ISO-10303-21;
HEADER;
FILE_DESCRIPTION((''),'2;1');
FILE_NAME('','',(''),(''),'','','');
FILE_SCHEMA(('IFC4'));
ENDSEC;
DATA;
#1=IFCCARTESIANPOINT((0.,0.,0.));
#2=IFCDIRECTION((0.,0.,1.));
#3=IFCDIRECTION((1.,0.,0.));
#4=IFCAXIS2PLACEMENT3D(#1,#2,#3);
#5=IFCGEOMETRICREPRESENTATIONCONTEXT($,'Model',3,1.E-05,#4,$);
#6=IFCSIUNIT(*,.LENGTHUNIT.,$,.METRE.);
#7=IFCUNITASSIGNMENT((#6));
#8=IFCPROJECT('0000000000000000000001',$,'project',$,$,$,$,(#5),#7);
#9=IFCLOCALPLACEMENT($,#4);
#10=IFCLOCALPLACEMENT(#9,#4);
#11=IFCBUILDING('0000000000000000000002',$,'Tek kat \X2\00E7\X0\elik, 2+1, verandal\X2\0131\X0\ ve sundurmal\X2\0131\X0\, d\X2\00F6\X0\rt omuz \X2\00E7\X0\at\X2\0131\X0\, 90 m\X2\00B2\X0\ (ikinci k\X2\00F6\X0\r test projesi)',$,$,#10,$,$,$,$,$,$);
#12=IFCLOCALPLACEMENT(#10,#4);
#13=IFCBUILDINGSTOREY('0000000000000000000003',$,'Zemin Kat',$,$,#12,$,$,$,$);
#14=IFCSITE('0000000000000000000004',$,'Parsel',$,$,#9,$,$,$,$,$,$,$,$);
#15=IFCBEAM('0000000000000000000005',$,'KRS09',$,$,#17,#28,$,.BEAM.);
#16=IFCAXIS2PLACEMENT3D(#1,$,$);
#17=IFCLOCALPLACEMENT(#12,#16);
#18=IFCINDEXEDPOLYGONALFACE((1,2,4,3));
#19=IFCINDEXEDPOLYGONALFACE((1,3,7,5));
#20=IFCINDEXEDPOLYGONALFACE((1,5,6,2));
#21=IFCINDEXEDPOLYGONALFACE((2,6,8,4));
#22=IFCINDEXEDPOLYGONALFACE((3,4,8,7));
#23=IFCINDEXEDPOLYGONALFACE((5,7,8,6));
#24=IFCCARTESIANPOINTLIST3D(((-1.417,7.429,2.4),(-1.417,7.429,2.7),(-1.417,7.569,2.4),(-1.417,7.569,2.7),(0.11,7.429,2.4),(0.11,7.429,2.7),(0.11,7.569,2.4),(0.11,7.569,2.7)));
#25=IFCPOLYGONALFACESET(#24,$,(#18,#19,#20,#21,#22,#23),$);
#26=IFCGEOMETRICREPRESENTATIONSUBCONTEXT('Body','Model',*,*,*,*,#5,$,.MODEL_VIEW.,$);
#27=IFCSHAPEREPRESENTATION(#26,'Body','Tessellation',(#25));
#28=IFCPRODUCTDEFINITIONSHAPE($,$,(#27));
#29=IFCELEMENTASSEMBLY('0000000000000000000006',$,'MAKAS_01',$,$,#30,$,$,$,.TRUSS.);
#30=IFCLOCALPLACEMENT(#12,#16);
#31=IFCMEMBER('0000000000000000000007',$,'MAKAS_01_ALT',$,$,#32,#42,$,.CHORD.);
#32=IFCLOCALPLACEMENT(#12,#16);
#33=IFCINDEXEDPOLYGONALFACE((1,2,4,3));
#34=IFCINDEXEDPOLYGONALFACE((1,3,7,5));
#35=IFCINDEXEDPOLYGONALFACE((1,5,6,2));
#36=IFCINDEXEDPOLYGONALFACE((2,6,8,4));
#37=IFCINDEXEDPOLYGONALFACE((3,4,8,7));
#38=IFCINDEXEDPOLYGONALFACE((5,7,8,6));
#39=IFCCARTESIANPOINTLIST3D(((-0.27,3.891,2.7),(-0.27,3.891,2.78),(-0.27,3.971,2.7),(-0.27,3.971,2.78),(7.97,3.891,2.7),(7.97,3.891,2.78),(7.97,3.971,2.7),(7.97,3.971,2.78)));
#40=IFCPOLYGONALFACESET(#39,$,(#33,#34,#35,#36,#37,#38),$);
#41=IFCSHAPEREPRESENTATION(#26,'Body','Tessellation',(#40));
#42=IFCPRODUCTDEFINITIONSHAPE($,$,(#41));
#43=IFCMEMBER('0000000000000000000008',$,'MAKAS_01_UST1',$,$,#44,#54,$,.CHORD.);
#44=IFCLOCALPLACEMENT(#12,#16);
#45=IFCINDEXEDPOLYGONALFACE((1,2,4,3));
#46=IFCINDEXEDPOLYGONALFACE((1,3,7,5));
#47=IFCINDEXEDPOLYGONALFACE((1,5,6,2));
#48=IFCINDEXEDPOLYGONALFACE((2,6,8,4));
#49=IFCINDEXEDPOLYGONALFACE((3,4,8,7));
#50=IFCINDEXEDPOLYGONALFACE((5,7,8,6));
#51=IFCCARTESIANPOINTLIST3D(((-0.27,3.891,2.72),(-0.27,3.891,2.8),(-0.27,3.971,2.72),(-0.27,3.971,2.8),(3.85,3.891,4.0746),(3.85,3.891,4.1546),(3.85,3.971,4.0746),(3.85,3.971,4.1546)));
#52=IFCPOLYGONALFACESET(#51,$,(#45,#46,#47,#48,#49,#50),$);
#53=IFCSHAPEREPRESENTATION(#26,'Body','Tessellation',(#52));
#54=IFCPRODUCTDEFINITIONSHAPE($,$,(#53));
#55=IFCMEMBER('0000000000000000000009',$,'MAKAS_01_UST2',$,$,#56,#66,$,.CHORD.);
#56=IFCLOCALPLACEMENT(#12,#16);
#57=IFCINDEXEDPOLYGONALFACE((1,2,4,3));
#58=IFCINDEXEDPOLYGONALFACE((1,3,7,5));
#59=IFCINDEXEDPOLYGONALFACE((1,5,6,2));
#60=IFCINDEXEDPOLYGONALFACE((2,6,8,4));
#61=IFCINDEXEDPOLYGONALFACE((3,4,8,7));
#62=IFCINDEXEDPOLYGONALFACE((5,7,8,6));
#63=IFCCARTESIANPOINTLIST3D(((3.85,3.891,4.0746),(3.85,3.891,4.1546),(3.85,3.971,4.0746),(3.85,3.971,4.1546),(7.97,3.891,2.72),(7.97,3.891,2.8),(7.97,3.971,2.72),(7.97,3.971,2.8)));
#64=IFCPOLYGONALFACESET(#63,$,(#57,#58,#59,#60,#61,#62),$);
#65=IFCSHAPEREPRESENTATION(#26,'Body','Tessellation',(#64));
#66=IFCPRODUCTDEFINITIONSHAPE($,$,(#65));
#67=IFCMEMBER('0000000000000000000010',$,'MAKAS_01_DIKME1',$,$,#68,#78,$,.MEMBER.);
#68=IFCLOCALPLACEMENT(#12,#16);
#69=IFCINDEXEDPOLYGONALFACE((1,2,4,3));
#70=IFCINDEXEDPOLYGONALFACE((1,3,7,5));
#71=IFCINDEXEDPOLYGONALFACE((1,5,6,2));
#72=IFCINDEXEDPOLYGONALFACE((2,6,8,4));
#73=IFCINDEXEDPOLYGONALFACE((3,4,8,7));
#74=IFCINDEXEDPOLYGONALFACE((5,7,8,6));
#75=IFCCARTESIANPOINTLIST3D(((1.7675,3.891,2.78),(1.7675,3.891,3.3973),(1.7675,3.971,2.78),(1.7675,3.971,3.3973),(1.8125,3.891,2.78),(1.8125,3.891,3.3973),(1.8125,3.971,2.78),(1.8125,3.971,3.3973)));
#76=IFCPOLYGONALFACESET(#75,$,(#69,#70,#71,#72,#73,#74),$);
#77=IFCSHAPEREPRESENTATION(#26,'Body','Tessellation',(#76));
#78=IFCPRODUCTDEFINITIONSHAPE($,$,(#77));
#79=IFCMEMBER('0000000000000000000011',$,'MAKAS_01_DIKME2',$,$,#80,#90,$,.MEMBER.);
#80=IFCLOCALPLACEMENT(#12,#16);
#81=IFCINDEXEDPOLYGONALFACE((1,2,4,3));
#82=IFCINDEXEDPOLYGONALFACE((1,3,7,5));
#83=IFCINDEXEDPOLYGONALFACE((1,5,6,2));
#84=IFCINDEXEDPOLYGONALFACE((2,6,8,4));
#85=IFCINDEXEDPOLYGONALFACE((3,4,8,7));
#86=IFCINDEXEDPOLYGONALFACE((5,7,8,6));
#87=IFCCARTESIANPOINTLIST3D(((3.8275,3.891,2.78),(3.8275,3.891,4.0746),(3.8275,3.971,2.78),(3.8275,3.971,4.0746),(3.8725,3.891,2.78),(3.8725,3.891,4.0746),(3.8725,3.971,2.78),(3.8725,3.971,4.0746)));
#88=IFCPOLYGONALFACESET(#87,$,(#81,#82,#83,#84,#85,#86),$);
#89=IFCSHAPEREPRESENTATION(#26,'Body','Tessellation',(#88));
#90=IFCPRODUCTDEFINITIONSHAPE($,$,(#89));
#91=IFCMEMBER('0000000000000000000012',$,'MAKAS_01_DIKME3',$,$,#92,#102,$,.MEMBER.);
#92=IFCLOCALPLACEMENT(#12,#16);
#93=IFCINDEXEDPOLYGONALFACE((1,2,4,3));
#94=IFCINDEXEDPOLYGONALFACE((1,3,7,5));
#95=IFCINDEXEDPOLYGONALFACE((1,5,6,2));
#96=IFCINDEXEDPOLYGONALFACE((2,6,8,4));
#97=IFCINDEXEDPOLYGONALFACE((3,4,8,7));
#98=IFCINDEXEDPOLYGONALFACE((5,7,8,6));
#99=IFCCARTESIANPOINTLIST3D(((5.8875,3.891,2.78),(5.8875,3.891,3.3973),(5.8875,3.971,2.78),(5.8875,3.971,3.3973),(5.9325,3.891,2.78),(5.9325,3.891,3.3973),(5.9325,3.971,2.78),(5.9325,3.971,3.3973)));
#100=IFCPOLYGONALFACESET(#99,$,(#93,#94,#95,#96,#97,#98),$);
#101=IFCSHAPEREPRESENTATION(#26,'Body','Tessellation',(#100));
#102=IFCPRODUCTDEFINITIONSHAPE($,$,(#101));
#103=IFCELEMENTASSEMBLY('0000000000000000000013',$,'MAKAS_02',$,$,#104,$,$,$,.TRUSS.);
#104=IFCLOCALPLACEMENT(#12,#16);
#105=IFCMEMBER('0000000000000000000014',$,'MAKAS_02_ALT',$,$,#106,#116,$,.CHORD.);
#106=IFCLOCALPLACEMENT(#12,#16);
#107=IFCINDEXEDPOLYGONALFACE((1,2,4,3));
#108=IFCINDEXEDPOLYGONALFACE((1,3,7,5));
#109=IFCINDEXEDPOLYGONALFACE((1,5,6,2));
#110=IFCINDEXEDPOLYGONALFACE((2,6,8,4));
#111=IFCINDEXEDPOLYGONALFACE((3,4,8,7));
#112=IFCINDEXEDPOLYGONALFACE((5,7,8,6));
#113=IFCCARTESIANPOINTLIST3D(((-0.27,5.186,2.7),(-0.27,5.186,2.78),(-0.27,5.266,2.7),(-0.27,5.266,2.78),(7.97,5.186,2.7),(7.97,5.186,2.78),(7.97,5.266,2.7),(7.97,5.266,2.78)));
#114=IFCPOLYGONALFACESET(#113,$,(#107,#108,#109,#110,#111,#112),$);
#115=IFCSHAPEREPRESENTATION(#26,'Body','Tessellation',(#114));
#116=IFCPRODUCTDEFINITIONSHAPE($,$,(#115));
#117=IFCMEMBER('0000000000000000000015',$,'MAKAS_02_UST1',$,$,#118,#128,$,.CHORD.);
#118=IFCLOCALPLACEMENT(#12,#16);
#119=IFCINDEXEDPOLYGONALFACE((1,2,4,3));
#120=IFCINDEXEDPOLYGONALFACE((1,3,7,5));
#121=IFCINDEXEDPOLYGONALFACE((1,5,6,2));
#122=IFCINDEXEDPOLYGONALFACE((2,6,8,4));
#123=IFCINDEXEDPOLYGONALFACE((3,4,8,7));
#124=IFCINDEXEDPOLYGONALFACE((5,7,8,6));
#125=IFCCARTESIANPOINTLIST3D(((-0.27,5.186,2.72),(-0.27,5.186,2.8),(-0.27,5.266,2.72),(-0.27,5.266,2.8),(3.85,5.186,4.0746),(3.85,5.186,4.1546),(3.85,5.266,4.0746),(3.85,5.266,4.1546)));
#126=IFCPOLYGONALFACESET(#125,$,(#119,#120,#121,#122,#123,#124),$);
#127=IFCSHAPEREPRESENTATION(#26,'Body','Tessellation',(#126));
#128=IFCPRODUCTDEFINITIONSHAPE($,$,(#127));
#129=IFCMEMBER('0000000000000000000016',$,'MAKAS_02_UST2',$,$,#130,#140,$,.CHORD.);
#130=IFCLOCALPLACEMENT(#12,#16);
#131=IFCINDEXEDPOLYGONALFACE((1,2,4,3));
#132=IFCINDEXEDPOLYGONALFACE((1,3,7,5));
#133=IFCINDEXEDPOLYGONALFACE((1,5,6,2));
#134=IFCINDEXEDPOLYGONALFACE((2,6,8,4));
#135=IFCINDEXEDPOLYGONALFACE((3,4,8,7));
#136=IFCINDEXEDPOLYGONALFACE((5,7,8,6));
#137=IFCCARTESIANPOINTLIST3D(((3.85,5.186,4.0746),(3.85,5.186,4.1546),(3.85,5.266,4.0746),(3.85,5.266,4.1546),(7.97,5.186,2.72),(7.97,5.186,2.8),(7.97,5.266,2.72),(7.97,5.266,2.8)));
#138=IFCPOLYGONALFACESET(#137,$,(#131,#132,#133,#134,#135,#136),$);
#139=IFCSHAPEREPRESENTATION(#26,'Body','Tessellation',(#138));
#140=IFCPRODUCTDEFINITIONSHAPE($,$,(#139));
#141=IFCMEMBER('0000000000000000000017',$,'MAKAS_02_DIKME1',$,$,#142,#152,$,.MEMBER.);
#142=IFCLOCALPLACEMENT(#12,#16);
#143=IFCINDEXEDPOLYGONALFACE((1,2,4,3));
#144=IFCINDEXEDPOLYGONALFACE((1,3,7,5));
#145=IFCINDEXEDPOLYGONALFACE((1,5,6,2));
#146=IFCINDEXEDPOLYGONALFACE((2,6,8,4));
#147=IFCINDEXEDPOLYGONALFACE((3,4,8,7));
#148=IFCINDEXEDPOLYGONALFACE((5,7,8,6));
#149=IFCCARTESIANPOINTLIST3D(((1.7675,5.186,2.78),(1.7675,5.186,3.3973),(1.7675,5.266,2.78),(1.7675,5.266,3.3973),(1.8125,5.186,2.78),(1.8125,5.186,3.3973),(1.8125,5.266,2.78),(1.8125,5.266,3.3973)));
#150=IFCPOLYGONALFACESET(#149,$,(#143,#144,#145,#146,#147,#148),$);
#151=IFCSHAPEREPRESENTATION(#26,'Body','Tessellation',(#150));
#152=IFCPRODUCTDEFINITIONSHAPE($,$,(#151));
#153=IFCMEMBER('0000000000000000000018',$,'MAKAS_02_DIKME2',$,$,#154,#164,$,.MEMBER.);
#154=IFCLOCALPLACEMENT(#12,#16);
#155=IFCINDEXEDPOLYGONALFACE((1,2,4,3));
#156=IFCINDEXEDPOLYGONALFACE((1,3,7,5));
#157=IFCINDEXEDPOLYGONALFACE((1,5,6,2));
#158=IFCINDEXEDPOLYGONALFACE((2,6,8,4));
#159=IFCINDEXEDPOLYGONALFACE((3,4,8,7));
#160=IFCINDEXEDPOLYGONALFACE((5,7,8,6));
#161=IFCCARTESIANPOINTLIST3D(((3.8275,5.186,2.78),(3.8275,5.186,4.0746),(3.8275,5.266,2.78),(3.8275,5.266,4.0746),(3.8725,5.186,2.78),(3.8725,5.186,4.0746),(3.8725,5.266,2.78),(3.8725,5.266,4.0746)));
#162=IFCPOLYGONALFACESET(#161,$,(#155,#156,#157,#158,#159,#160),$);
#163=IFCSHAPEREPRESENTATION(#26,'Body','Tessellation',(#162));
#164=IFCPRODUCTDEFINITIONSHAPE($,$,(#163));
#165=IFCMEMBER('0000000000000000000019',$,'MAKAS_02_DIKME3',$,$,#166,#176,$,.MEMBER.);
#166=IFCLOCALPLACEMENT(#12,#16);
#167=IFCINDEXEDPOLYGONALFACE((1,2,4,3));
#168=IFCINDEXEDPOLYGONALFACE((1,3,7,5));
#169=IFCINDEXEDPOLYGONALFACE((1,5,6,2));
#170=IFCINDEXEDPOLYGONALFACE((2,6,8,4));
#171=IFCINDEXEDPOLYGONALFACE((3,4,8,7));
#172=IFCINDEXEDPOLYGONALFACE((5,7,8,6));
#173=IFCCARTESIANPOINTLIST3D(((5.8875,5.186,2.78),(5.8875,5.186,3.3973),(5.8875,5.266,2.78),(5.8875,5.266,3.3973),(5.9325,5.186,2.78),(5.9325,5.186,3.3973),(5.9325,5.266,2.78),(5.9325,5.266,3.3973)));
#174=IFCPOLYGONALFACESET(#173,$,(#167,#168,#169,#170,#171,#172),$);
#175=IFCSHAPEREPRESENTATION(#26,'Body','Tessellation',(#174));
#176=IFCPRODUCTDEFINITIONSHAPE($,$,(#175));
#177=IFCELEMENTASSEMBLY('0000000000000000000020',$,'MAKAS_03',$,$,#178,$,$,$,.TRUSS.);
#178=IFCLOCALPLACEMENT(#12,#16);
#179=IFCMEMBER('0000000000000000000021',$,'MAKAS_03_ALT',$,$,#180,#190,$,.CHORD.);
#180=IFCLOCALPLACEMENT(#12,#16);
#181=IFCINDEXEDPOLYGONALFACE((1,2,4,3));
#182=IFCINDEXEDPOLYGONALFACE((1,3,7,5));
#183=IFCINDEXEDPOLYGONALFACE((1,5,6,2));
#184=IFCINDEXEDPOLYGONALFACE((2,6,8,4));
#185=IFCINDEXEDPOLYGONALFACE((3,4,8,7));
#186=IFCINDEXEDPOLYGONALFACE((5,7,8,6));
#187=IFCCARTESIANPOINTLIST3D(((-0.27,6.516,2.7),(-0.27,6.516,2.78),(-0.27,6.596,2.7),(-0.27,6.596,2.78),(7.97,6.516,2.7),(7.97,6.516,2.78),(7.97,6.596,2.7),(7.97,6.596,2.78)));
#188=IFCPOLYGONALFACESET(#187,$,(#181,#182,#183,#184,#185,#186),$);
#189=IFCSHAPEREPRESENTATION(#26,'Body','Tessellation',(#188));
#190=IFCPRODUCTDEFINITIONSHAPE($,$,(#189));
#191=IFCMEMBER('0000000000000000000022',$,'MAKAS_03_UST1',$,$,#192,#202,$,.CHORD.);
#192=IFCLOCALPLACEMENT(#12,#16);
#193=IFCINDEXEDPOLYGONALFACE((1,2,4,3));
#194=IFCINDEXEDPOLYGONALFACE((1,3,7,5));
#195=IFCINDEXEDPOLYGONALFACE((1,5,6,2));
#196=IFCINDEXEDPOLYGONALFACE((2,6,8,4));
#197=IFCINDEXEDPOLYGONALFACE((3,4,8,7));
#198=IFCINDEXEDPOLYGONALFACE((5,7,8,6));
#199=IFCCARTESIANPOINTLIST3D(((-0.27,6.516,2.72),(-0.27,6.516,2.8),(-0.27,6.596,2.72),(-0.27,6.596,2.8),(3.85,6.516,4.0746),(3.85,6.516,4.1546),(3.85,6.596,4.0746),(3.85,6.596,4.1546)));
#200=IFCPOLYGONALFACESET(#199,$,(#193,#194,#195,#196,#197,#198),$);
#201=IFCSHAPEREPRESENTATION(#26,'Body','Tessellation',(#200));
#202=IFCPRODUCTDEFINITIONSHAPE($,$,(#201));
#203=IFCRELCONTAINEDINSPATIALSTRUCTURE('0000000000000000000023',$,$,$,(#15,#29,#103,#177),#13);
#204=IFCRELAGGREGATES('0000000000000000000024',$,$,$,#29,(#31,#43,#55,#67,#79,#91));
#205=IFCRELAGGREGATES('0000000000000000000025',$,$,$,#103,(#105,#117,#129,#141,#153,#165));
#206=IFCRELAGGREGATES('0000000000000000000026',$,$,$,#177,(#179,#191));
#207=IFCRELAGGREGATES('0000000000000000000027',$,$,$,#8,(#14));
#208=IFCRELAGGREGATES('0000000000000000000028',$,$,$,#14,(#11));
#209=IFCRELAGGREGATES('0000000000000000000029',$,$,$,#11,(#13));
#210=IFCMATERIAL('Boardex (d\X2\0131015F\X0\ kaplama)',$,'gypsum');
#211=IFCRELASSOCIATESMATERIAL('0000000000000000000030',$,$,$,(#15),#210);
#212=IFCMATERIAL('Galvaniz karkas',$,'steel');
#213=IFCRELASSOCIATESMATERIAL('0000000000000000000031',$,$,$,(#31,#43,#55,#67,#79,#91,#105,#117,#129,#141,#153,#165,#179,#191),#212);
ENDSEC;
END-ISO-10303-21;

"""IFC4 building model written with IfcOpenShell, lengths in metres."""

from ifc_helpers import new_model, si_unit, frame, origin_with_axes, place, context, subcontext, project, spatial, line, indexed_curve, outline, extrude, material, element, aggregate, save


model = new_model("IFC4")

# Units and contexts
model_context = context("Model", 3, precision=1e-05, world=origin_with_axes())
body_context = subcontext(model_context, "Body", "Model", "MODEL_VIEW")
ifc_project = project(units=[si_unit("LENGTHUNIT", "METRE")], contexts=[model_context])

# Site, building, storey
site_placement = place(None, origin_with_axes())
site = spatial("IfcSite", under=ifc_project, at=site_placement, Name="Parsel")
building_placement = place(site_placement, origin_with_axes())
building = spatial("IfcBuilding", under=site, at=building_placement, Name="Tek kat çelik, 2+1, verandalı ve sundurmalı, dört omuz çatı, 90 m² (ikinci kör test projesi)")
storey_placement = place(building_placement, origin_with_axes())
storey = spatial("IfcBuildingStorey", under=building, at=storey_placement, Name="Zemin Kat")

# Beam
ifc_material_1 = material(Name="Boardex (dış kaplama)", Category="gypsum")
beam_placement = place(storey_placement, origin_with_axes())
element("IfcBeam", 1, at=beam_placement, inside=storey, material=ifc_material_1, Name="KRS09", PredefinedType="BEAM", context=body_context, shape_type="SweptSolid", body=[
    extrude(outline(indexed_curve([(0.0, 0.0), (1.527, 0.0), (1.527, 0.14), (0.0, 0.14)], segments=[line(1, 2, 3, 4, 1)])), frame((-1.417, 7.429, 2.4), z_axis=(0.0, 0.0, 1.0), x_axis=(1.0, 0.0, 0.0)), (0.0, 0.0, 1.0), 0.3),
])

# Element assemblies, members
assembly_1_placement = place(storey_placement, origin_with_axes())
assembly_1 = element("IfcElementAssembly", 2, at=assembly_1_placement, inside=storey, Name="MAKAS_01", PredefinedType="TRUSS")
ifc_material_2 = material(Name="Galvaniz karkas", Category="steel")
member_1_placement = place(assembly_1_placement, origin_with_axes())
member_1 = element("IfcMember", 3, at=member_1_placement, material=ifc_material_2, Name="MAKAS_01_ALT", PredefinedType="CHORD", context=body_context, shape_type="SweptSolid", body=[
    extrude(outline(indexed_curve([(-0.27, 2.7), (7.97, 2.7), (7.97, 2.78), (-0.27, 2.78)], segments=[line(1, 2, 3, 4, 1)])), frame((0.0, 3.971, 0.0), z_axis=(0.0, -1.0, 0.0), x_axis=(1.0, 0.0, 0.0)), (0.0, 0.0, 1.0), 0.08),
])
member_2_placement = place(assembly_1_placement, origin_with_axes())
member_2 = element("IfcMember", 4, at=member_2_placement, material=ifc_material_2, Name="MAKAS_01_UST1", PredefinedType="CHORD", context=body_context, shape_type="SweptSolid", body=[
    extrude(outline(indexed_curve([(-0.27, 2.72), (3.85, 4.0746), (3.85, 4.1546), (-0.27, 2.8)], segments=[line(1, 2, 3, 4, 1)])), frame((0.0, 3.971, 0.0), z_axis=(0.0, -1.0, 0.0), x_axis=(1.0, 0.0, 0.0)), (0.0, 0.0, 1.0), 0.08),
])
member_3_placement = place(assembly_1_placement, origin_with_axes())
member_3 = element("IfcMember", 5, at=member_3_placement, material=ifc_material_2, Name="MAKAS_01_UST2", PredefinedType="CHORD", context=body_context, shape_type="SweptSolid", body=[
    extrude(outline(indexed_curve([(3.85, 4.0746), (7.97, 2.72), (7.97, 2.8), (3.85, 4.1546)], segments=[line(1, 2, 3, 4, 1)])), frame((0.0, 3.971, 0.0), z_axis=(0.0, -1.0, 0.0), x_axis=(1.0, 0.0, 0.0)), (0.0, 0.0, 1.0), 0.08),
])
member_4_placement = place(assembly_1_placement, origin_with_axes())
member_4 = element("IfcMember", 6, at=member_4_placement, material=ifc_material_2, Name="MAKAS_01_DIKME1", PredefinedType="MEMBER", context=body_context, shape_type="SweptSolid", body=[
    extrude(outline(indexed_curve([(1.7675, 2.78), (1.8125, 2.78), (1.8125, 3.3973), (1.7675, 3.3973)], segments=[line(1, 2, 3, 4, 1)])), frame((0.0, 3.971, 0.0), z_axis=(0.0, -1.0, 0.0), x_axis=(1.0, 0.0, 0.0)), (0.0, 0.0, 1.0), 0.08),
])
member_5_placement = place(assembly_1_placement, origin_with_axes())
member_5 = element("IfcMember", 7, at=member_5_placement, material=ifc_material_2, Name="MAKAS_01_DIKME2", PredefinedType="MEMBER", context=body_context, shape_type="SweptSolid", body=[
    extrude(outline(indexed_curve([(3.8275, 2.78), (3.8725, 2.78), (3.8725, 4.0746), (3.8275, 4.0746)], segments=[line(1, 2, 3, 4, 1)])), frame((0.0, 3.971, 0.0), z_axis=(0.0, -1.0, 0.0), x_axis=(1.0, 0.0, 0.0)), (0.0, 0.0, 1.0), 0.08),
])
member_6_placement = place(assembly_1_placement, origin_with_axes())
member_6 = element("IfcMember", 8, at=member_6_placement, material=ifc_material_2, Name="MAKAS_01_DIKME3", PredefinedType="MEMBER", context=body_context, shape_type="SweptSolid", body=[
    extrude(outline(indexed_curve([(5.8875, 2.78), (5.9325, 2.78), (5.9325, 3.3973), (5.8875, 3.3973)], segments=[line(1, 2, 3, 4, 1)])), frame((0.0, 3.971, 0.0), z_axis=(0.0, -1.0, 0.0), x_axis=(1.0, 0.0, 0.0)), (0.0, 0.0, 1.0), 0.08),
])
aggregate(assembly_1, [member_1, member_2, member_3, member_4, member_5, member_6])
assembly_2_placement = place(storey_placement, origin_with_axes())
assembly_2 = element("IfcElementAssembly", 9, at=assembly_2_placement, inside=storey, Name="MAKAS_02", PredefinedType="TRUSS")
member_7_placement = place(assembly_2_placement, origin_with_axes())
member_7 = element("IfcMember", 10, at=member_7_placement, material=ifc_material_2, Name="MAKAS_02_ALT", PredefinedType="CHORD", context=body_context, shape_type="SweptSolid", body=[
    extrude(outline(indexed_curve([(-0.27, 2.7), (7.97, 2.7), (7.97, 2.78), (-0.27, 2.78)], segments=[line(1, 2, 3, 4, 1)])), frame((0.0, 5.266, 0.0), z_axis=(0.0, -1.0, 0.0), x_axis=(1.0, 0.0, 0.0)), (0.0, 0.0, 1.0), 0.08),
])
member_8_placement = place(assembly_2_placement, origin_with_axes())
member_8 = element("IfcMember", 11, at=member_8_placement, material=ifc_material_2, Name="MAKAS_02_UST1", PredefinedType="CHORD", context=body_context, shape_type="SweptSolid", body=[
    extrude(outline(indexed_curve([(-0.27, 2.72), (3.85, 4.0746), (3.85, 4.1546), (-0.27, 2.8)], segments=[line(1, 2, 3, 4, 1)])), frame((0.0, 5.266, 0.0), z_axis=(0.0, -1.0, 0.0), x_axis=(1.0, 0.0, 0.0)), (0.0, 0.0, 1.0), 0.08),
])
member_9_placement = place(assembly_2_placement, origin_with_axes())
member_9 = element("IfcMember", 12, at=member_9_placement, material=ifc_material_2, Name="MAKAS_02_UST2", PredefinedType="CHORD", context=body_context, shape_type="SweptSolid", body=[
    extrude(outline(indexed_curve([(3.85, 4.0746), (7.97, 2.72), (7.97, 2.8), (3.85, 4.1546)], segments=[line(1, 2, 3, 4, 1)])), frame((0.0, 5.266, 0.0), z_axis=(0.0, -1.0, 0.0), x_axis=(1.0, 0.0, 0.0)), (0.0, 0.0, 1.0), 0.08),
])
member_10_placement = place(assembly_2_placement, origin_with_axes())
member_10 = element("IfcMember", 13, at=member_10_placement, material=ifc_material_2, Name="MAKAS_02_DIKME1", PredefinedType="MEMBER", context=body_context, shape_type="SweptSolid", body=[
    extrude(outline(indexed_curve([(1.7675, 2.78), (1.8125, 2.78), (1.8125, 3.3973), (1.7675, 3.3973)], segments=[line(1, 2, 3, 4, 1)])), frame((0.0, 5.266, 0.0), z_axis=(0.0, -1.0, 0.0), x_axis=(1.0, 0.0, 0.0)), (0.0, 0.0, 1.0), 0.08),
])
member_11_placement = place(assembly_2_placement, origin_with_axes())
member_11 = element("IfcMember", 14, at=member_11_placement, material=ifc_material_2, Name="MAKAS_02_DIKME2", PredefinedType="MEMBER", context=body_context, shape_type="SweptSolid", body=[
    extrude(outline(indexed_curve([(3.8275, 2.78), (3.8725, 2.78), (3.8725, 4.0746), (3.8275, 4.0746)], segments=[line(1, 2, 3, 4, 1)])), frame((0.0, 5.266, 0.0), z_axis=(0.0, -1.0, 0.0), x_axis=(1.0, 0.0, 0.0)), (0.0, 0.0, 1.0), 0.08),
])
member_12_placement = place(assembly_2_placement, origin_with_axes())
member_12 = element("IfcMember", 15, at=member_12_placement, material=ifc_material_2, Name="MAKAS_02_DIKME3", PredefinedType="MEMBER", context=body_context, shape_type="SweptSolid", body=[
    extrude(outline(indexed_curve([(5.8875, 2.78), (5.9325, 2.78), (5.9325, 3.3973), (5.8875, 3.3973)], segments=[line(1, 2, 3, 4, 1)])), frame((0.0, 5.266, 0.0), z_axis=(0.0, -1.0, 0.0), x_axis=(1.0, 0.0, 0.0)), (0.0, 0.0, 1.0), 0.08),
])
aggregate(assembly_2, [member_7, member_8, member_9, member_10, member_11, member_12])
assembly_3_placement = place(storey_placement, origin_with_axes())
assembly_3 = element("IfcElementAssembly", 16, at=assembly_3_placement, inside=storey, Name="MAKAS_03", PredefinedType="TRUSS")
member_13_placement = place(assembly_3_placement, origin_with_axes())
member_13 = element("IfcMember", 17, at=member_13_placement, material=ifc_material_2, Name="MAKAS_03_ALT", PredefinedType="CHORD", context=body_context, shape_type="SweptSolid", body=[
    extrude(outline(indexed_curve([(-0.27, 2.7), (7.97, 2.7), (7.97, 2.78), (-0.27, 2.78)], segments=[line(1, 2, 3, 4, 1)])), frame((0.0, 6.596, 0.0), z_axis=(0.0, -1.0, 0.0), x_axis=(1.0, 0.0, 0.0)), (0.0, 0.0, 1.0), 0.08),
])
member_14_placement = place(assembly_3_placement, origin_with_axes())
member_14 = element("IfcMember", 18, at=member_14_placement, material=ifc_material_2, Name="MAKAS_03_UST1", PredefinedType="CHORD", context=body_context, shape_type="SweptSolid", body=[
    extrude(outline(indexed_curve([(-0.27, 2.72), (3.85, 4.0746), (3.85, 4.1546), (-0.27, 2.8)], segments=[line(1, 2, 3, 4, 1)])), frame((0.0, 6.596, 0.0), z_axis=(0.0, -1.0, 0.0), x_axis=(1.0, 0.0, 0.0)), (0.0, 0.0, 1.0), 0.08),
])
aggregate(assembly_3, [member_13, member_14])

save(model, "model.ifc")
